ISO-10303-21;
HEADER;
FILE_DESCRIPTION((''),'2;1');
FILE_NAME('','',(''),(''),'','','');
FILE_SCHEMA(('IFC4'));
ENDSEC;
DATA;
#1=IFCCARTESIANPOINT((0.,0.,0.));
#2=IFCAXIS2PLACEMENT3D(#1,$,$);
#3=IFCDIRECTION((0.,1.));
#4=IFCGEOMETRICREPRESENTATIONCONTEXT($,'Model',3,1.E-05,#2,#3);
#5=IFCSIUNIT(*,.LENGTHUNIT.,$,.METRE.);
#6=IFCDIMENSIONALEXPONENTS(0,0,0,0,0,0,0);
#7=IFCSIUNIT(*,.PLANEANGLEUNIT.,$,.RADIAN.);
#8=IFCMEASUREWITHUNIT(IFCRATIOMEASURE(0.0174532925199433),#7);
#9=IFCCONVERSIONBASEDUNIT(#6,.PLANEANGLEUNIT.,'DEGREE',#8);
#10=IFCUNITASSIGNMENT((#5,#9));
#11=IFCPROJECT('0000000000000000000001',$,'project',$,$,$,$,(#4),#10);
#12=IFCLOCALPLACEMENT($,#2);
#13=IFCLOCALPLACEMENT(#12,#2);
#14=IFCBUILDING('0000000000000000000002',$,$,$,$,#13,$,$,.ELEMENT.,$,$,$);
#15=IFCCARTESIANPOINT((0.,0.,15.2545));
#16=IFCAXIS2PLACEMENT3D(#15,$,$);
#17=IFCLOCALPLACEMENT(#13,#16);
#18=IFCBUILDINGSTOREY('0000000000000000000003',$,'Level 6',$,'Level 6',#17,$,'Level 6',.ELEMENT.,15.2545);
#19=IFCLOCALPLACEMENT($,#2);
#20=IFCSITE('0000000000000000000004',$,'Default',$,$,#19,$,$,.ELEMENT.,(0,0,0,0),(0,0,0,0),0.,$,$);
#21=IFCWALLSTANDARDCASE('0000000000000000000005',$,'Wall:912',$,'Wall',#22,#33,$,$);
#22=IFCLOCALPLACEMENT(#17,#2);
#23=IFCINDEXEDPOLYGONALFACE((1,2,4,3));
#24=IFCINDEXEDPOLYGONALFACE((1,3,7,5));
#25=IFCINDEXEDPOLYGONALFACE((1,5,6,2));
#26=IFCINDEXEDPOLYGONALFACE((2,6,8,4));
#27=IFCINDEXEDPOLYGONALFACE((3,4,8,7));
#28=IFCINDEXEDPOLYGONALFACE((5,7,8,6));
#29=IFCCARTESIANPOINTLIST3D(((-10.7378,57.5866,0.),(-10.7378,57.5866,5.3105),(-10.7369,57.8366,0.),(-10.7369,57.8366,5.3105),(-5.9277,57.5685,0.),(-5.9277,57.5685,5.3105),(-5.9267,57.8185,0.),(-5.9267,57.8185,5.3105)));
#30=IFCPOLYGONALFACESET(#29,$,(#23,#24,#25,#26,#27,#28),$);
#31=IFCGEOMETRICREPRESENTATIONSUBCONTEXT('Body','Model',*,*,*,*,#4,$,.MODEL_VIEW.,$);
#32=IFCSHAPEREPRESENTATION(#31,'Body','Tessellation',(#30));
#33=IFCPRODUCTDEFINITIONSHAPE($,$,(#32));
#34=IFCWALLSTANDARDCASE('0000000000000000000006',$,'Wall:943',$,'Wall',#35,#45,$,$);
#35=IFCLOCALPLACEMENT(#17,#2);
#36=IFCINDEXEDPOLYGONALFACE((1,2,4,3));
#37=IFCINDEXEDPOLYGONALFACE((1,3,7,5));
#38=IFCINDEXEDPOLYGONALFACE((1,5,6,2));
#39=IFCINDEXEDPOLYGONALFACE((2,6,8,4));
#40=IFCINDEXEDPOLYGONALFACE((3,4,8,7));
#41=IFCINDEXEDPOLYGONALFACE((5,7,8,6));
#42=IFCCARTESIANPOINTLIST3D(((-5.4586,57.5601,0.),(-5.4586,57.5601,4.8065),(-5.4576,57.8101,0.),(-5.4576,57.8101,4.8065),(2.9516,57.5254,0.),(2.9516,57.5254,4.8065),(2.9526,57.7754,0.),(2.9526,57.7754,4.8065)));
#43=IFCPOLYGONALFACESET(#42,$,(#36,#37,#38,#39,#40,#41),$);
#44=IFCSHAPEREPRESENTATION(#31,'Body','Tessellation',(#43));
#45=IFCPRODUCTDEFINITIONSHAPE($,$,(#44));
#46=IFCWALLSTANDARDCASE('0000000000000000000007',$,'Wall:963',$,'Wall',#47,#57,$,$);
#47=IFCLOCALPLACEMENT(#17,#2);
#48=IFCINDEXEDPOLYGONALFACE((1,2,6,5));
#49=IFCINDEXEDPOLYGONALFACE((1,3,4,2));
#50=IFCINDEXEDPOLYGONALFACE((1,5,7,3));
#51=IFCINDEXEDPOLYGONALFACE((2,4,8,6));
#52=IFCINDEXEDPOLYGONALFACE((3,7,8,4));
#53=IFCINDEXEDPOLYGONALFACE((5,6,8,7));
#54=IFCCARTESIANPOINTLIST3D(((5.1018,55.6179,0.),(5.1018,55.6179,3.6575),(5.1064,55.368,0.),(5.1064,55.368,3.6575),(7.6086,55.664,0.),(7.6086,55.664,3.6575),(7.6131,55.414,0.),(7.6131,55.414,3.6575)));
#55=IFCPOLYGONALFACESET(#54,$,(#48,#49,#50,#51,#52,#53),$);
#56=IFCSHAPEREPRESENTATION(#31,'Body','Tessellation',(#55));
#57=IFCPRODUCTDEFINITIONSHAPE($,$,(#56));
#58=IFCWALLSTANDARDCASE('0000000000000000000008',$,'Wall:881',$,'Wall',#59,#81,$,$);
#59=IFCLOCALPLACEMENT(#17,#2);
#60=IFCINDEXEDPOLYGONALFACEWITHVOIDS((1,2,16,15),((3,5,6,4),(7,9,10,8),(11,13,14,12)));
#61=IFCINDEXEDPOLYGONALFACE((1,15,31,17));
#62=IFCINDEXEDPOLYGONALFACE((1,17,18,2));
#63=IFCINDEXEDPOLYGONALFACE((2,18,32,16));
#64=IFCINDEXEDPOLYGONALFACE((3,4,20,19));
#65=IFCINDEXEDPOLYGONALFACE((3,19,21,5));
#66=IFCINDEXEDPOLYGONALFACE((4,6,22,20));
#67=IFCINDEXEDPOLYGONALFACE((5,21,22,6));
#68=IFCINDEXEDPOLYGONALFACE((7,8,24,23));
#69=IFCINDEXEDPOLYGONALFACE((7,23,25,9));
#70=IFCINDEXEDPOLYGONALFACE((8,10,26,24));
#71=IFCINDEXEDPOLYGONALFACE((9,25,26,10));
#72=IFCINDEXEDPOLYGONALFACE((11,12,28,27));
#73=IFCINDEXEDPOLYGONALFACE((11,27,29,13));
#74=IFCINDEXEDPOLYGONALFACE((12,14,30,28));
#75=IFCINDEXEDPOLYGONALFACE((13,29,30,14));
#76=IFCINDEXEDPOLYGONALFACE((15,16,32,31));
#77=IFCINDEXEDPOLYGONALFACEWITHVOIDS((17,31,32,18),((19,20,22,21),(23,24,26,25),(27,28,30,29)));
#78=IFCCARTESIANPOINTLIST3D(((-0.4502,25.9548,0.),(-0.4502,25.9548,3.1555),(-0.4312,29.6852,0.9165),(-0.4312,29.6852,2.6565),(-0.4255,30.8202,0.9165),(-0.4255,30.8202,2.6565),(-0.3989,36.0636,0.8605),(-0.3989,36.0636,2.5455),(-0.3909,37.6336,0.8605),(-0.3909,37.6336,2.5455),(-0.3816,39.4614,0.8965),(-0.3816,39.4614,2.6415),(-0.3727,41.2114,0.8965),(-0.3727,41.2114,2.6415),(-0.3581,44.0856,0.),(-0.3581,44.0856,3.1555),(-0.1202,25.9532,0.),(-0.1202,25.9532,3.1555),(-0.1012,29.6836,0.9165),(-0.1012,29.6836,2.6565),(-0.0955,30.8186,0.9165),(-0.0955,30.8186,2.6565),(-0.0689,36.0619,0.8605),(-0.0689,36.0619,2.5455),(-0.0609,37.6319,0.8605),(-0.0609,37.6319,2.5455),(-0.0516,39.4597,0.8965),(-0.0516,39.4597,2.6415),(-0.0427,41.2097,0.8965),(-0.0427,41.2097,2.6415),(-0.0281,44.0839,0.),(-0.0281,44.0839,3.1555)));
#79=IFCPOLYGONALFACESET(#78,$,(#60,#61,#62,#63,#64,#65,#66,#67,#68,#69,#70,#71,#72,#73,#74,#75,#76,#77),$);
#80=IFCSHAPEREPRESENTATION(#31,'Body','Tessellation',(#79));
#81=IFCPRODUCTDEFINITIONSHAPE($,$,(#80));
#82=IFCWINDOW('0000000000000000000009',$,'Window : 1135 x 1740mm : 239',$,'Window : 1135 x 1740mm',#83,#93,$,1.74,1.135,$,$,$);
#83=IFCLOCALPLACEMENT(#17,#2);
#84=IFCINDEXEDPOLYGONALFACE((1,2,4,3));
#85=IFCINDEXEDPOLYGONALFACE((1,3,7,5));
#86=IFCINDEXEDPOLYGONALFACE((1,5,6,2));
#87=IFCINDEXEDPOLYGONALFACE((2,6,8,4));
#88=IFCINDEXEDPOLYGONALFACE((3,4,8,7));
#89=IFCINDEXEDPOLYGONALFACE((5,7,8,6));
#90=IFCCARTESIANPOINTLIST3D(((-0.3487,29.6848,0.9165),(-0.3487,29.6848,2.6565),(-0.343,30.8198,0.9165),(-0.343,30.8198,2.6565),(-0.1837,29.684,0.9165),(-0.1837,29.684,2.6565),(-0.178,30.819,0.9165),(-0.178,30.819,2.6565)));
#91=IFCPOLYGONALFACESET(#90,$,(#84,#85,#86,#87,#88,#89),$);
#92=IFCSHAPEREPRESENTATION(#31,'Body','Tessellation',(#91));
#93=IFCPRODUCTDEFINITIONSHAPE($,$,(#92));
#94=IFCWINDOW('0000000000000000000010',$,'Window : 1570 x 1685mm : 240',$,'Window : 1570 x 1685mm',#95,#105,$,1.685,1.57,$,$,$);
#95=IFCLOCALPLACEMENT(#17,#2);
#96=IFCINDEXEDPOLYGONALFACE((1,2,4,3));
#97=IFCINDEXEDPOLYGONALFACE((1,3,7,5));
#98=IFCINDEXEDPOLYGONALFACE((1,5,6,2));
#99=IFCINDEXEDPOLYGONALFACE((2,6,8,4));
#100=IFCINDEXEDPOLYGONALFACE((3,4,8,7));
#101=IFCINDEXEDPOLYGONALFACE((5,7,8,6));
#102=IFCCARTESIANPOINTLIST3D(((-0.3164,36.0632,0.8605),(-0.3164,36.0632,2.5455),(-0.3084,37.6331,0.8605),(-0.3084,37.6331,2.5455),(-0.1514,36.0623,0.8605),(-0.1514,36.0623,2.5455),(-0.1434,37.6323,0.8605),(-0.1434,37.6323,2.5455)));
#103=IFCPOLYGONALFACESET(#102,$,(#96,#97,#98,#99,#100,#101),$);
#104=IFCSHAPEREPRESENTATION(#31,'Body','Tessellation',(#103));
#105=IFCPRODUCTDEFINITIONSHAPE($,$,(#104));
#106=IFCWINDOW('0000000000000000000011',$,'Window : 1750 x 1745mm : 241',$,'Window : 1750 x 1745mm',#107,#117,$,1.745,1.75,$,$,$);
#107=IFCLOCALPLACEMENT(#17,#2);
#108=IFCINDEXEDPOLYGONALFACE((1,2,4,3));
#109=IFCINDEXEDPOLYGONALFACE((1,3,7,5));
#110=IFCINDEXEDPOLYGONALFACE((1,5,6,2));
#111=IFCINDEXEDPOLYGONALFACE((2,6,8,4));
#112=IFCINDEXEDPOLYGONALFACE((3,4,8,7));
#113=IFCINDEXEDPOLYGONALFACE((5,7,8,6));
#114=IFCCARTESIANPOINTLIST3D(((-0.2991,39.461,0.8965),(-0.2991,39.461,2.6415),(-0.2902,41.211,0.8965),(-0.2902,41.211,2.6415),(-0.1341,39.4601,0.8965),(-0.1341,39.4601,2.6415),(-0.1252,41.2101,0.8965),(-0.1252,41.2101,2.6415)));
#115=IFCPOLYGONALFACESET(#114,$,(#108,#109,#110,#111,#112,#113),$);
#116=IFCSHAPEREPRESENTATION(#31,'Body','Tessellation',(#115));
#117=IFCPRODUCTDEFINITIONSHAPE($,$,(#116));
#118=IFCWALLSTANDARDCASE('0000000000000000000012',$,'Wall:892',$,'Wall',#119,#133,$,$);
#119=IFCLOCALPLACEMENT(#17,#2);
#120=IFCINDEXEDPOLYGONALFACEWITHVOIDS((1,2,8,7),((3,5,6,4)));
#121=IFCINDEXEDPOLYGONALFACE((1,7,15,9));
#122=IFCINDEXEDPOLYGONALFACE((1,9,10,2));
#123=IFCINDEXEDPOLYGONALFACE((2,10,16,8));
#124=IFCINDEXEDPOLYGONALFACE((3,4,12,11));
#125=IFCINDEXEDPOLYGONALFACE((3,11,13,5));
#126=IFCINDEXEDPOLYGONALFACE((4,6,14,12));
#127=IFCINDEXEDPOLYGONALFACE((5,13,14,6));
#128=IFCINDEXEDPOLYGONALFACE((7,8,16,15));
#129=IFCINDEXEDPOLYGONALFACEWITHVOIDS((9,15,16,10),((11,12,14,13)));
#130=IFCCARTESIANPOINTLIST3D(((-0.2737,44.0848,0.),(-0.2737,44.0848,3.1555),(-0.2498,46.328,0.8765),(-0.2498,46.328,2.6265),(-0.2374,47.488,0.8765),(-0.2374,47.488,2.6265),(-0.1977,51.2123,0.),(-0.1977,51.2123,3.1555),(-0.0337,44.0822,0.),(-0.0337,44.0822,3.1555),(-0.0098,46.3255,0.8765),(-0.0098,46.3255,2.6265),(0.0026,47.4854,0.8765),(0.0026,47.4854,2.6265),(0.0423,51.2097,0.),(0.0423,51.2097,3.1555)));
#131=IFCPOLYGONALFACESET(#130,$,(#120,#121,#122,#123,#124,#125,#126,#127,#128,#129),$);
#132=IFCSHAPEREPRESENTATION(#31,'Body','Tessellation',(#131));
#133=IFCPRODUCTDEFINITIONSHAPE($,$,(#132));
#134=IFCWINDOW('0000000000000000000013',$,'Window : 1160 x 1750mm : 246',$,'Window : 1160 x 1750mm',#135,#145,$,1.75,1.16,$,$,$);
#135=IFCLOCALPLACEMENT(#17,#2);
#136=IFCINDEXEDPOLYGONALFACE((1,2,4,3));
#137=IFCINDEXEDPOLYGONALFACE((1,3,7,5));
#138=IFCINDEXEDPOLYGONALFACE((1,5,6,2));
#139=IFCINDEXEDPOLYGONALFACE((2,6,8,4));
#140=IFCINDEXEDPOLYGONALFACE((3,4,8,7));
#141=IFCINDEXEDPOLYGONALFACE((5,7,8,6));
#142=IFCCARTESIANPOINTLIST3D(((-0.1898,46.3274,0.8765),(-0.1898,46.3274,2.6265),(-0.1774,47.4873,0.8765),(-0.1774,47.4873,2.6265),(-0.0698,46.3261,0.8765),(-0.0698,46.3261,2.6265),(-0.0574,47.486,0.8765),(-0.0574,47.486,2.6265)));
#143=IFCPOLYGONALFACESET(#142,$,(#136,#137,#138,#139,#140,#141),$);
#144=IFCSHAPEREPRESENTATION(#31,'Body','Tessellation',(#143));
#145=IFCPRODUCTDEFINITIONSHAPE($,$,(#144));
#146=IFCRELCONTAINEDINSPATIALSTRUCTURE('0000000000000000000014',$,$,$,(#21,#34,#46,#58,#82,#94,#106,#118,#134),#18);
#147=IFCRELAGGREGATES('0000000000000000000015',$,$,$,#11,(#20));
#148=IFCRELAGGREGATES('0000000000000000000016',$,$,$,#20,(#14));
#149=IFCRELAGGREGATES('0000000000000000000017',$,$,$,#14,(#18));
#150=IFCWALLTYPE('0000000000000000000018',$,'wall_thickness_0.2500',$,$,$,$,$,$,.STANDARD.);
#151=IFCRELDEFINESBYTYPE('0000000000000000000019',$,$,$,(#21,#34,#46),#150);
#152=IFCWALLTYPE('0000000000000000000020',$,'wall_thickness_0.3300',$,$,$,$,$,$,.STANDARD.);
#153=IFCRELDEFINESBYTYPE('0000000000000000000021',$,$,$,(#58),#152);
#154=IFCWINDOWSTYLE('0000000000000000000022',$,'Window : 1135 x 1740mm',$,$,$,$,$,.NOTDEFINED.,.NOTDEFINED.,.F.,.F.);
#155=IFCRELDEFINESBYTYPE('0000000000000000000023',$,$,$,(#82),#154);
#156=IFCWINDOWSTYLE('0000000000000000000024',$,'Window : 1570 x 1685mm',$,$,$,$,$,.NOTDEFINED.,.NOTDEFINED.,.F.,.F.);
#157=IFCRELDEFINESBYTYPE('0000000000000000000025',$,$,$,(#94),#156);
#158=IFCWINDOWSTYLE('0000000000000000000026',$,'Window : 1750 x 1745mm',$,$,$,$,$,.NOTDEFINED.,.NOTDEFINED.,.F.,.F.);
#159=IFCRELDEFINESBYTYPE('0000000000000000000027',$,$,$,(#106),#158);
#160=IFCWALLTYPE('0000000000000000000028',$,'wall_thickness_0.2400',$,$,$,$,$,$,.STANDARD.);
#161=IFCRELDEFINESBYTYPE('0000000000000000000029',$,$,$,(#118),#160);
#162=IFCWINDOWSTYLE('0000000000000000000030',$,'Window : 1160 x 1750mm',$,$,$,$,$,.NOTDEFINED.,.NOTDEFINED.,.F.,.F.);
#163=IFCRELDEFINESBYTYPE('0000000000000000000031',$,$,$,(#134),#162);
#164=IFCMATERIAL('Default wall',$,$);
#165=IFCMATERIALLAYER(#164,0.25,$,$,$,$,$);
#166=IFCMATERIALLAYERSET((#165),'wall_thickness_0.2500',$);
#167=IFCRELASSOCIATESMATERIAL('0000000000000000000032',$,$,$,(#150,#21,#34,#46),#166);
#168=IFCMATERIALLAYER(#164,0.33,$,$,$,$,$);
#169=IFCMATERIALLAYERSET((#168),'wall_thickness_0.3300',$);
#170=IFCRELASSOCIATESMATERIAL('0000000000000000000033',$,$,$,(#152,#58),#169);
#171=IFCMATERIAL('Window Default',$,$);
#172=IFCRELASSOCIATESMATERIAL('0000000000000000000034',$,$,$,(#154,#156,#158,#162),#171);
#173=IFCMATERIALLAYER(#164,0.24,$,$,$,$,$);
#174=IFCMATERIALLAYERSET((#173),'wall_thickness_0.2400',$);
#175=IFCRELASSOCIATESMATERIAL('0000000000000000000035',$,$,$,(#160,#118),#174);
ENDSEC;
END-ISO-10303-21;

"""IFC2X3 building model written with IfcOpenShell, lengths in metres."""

from ifc_helpers import new_model, entity, si_unit, converted_unit, direction, frame, frame_2d, origin, origin_2d_with_axis, place, context, subcontext, project, spatial, polyline, rectangle, outline, extrude, source, transform, mapped, material, layer, layer_set, layer_usage, type_object, type_shapes, element, fill, save


model = new_model("IFC2X3")

# Units and contexts
model_context = context("Model", 3, precision=1e-05, world=origin(), true_north=direction((0.0, 1.0)))
body_context = subcontext(model_context, "Body", "Model", "MODEL_VIEW")
ifc_project = project(units=[si_unit("LENGTHUNIT", "METRE"), converted_unit("PLANEANGLEUNIT", "DEGREE", entity("IfcRatioMeasure", 0.0174532925199433), si_unit("PLANEANGLEUNIT", "RADIAN"), dimensions=[0, 0, 0, 0, 0, 0, 0])], contexts=[model_context])

# Site, building, storey
site_placement = place(None, origin())
site = spatial("IfcSite", under=ifc_project, at=site_placement, Name="Default", CompositionType="ELEMENT", RefLatitude=(0, 0, 0, 0), RefLongitude=(0, 0, 0, 0), RefElevation=0.0)
placement = place(None, origin())
building_placement = place(placement, origin())
building = spatial("IfcBuilding", under=site, at=building_placement, CompositionType="ELEMENT")
storey_placement = place(building_placement, frame((0.0, 0.0, 15.2545)))
storey = spatial("IfcBuildingStorey", under=building, at=storey_placement, Name="Level 6", ObjectType="Level 6", LongName="Level 6", CompositionType="ELEMENT", Elevation=15.2545)

# Shared definitions
ifc_material_1 = material(Name="Default wall")

# Shared definitions
ifc_layer_1 = layer(ifc_material_1, 0.25)
ifc_layer_set_1 = layer_set([ifc_layer_1], Name="wall_thickness_0.2500")
ifc_layer_usage_1 = layer_usage(ifc_layer_set_1, "AXIS2", "POSITIVE", -0.125)
wall_type_1 = type_object("IfcWallType", Name="wall_thickness_0.2500", PredefinedType="STANDARD", material=ifc_layer_set_1)

# Walls
wall_1_placement = place(storey_placement, frame((-10.7374, 57.7116, 0.0), z_axis=(0.0, 0.0, 1.0), x_axis=(0.999993, -0.003777, 0.0)))
element("IfcWallStandardCase", 1, at=wall_1_placement, inside=storey, type_object=wall_type_1, material=ifc_layer_usage_1, Name="Wall:912", ObjectType="Wall", context=body_context, shape_type="SweptSolid", body=[
    extrude(outline(polyline([(4.8102, -0.125), (4.8102, 0.125), (0.0, 0.125), (0.0, -0.125), (4.8102, -0.125)])), origin(), (0.0, 0.0, 1.0), 5.3105),
])
wall_2_placement = place(storey_placement, frame((-5.4581, 57.6851, 0.0), z_axis=(0.0, 0.0, 1.0), x_axis=(0.999992, -0.004119, 0.0)))
element("IfcWallStandardCase", 2, at=wall_2_placement, inside=storey, type_object=wall_type_1, material=ifc_layer_usage_1, Name="Wall:943", ObjectType="Wall", context=body_context, shape_type="SweptSolid", body=[
    extrude(outline(polyline([(8.4103, -0.125), (8.4103, 0.125), (0.0, 0.125), (0.0, -0.125), (8.4103, -0.125)])), origin(), (0.0, 0.0, 1.0), 4.8065),
])
wall_3_placement = place(storey_placement, frame((5.1041, 55.4929, 0.0), z_axis=(0.0, 0.0, 1.0), x_axis=(0.999831, 0.018363, 0.0)))
element("IfcWallStandardCase", 3, at=wall_3_placement, inside=storey, type_object=wall_type_1, material=ifc_layer_usage_1, Name="Wall:963", ObjectType="Wall", context=body_context, shape_type="SweptSolid", body=[
    extrude(outline(polyline([(2.5072, -0.125), (2.5072, 0.125), (0.0, 0.125), (0.0, -0.125), (2.5072, -0.125)])), origin(), (0.0, 0.0, 1.0), 3.6575),
])

# Wall, openings, windows
ifc_layer_2 = layer(ifc_material_1, 0.33)
ifc_layer_set_2 = layer_set([ifc_layer_2], Name="wall_thickness_0.3300")
ifc_layer_usage_2 = layer_usage(ifc_layer_set_2, "AXIS2", "POSITIVE", -0.165)
wall_type_2 = type_object("IfcWallType", Name="wall_thickness_0.3300", PredefinedType="STANDARD", material=ifc_layer_set_2)
wall_4_placement = place(storey_placement, frame((-0.1931, 44.0847, 0.0), z_axis=(0.0, 0.0, 1.0), x_axis=(-0.005077, -0.999987, 0.0)))
wall_4 = element("IfcWallStandardCase", 4, at=wall_4_placement, inside=storey, type_object=wall_type_2, material=ifc_layer_usage_2, Name="Wall:881", ObjectType="Wall", context=body_context, shape_type="SweptSolid", body=[
    extrude(outline(polyline([(18.131, -0.165), (18.131, 0.165), (0.0, 0.165), (0.0, -0.165), (18.131, -0.165)])), origin(), (0.0, 0.0, 1.0), 3.1555),
])
opening_1_placement = place(wall_4_placement, frame((13.2655, -0.165, 0.9165)))
opening_1 = element("IfcOpeningElement", 5, at=opening_1_placement, cuts=wall_4, ObjectType="Opening", context=body_context, shape_type="SweptSolid", body=[
    extrude(rectangle(XDim=1.135, YDim=1.74, at=frame_2d((0.87, 0.5675), x_axis=(0.0, 1.0))), frame((0.0, 0.0, 0.0), z_axis=(0.0, 1.0, 0.0), x_axis=(0.0, 0.0, 1.0)), (0.0, 0.0, 1.0), 0.33),
])
opening_2_placement = place(wall_4_placement, frame((6.4521, -0.165, 0.8605)))
opening_2 = element("IfcOpeningElement", 6, at=opening_2_placement, cuts=wall_4, ObjectType="Opening", context=body_context, shape_type="SweptSolid", body=[
    extrude(rectangle(XDim=1.57, YDim=1.685, at=frame_2d((0.8425, 0.785), x_axis=(0.0, 1.0))), frame((0.0, 0.0, 0.0), z_axis=(0.0, 1.0, 0.0), x_axis=(0.0, 0.0, 1.0)), (0.0, 0.0, 1.0), 0.33),
])
opening_3_placement = place(wall_4_placement, frame((2.8742, -0.165, 0.8965)))
opening_3 = element("IfcOpeningElement", 7, at=opening_3_placement, cuts=wall_4, ObjectType="Opening", context=body_context, shape_type="SweptSolid", body=[
    extrude(rectangle(XDim=1.75, YDim=1.745, at=frame_2d((0.8725, 0.875), x_axis=(0.0, 1.0))), frame((0.0, 0.0, 0.0), z_axis=(0.0, 1.0, 0.0), x_axis=(0.0, 0.0, 1.0)), (0.0, 0.0, 1.0), 0.33),
])
ifc_material_2 = material(Name="Window Default")
window_style_1 = type_object("IfcWindowStyle", Name="Window : 1135 x 1740mm", ConstructionType="NOTDEFINED", OperationType="NOTDEFINED", ParameterTakesPrecedence=False, Sizeable=False, material=ifc_material_2)
shared_shape_1 = source(origin(), body_context, "Body", "SweptSolid", [
    extrude(rectangle(XDim=0.165, YDim=1.135, at=origin_2d_with_axis()), frame((0.5675, 0.165, 0.0), z_axis=(0.0, 0.0, 1.0), x_axis=(0.0, 1.0, 0.0)), (0.0, 0.0, 1.0), 1.74),
])
type_shapes(window_style_1, [shared_shape_1])
window_1_placement = place(opening_1_placement, origin())
window_1 = element("IfcWindow", 8, at=window_1_placement, inside=storey, type_object=window_style_1, Name="Window : 1135 x 1740mm : 239", ObjectType="Window : 1135 x 1740mm", OverallHeight=1.74, OverallWidth=1.135, context=body_context, shape_type="MappedRepresentation", body=[
    mapped(shared_shape_1, transform((0.0, 0.0, 0.0), scale=1.0)),
])
fill(opening_1, window_1)
window_style_2 = type_object("IfcWindowStyle", Name="Window : 1570 x 1685mm", ConstructionType="NOTDEFINED", OperationType="NOTDEFINED", ParameterTakesPrecedence=False, Sizeable=False, material=ifc_material_2)
shared_shape_2 = source(origin(), body_context, "Body", "SweptSolid", [
    extrude(rectangle(XDim=0.165, YDim=1.57, at=origin_2d_with_axis()), frame((0.785, 0.165, 0.0), z_axis=(0.0, 0.0, 1.0), x_axis=(0.0, 1.0, 0.0)), (0.0, 0.0, 1.0), 1.685),
])
type_shapes(window_style_2, [shared_shape_2])
window_2_placement = place(opening_2_placement, origin())
window_2 = element("IfcWindow", 9, at=window_2_placement, inside=storey, type_object=window_style_2, Name="Window : 1570 x 1685mm : 240", ObjectType="Window : 1570 x 1685mm", OverallHeight=1.685, OverallWidth=1.57, context=body_context, shape_type="MappedRepresentation", body=[
    mapped(shared_shape_2, transform((0.0, 0.0, 0.0), scale=1.0)),
])
fill(opening_2, window_2)
window_style_3 = type_object("IfcWindowStyle", Name="Window : 1750 x 1745mm", ConstructionType="NOTDEFINED", OperationType="NOTDEFINED", ParameterTakesPrecedence=False, Sizeable=False, material=ifc_material_2)
shared_shape_3 = source(origin(), body_context, "Body", "SweptSolid", [
    extrude(rectangle(XDim=0.165, YDim=1.75, at=origin_2d_with_axis()), frame((0.875, 0.165, 0.0), z_axis=(0.0, 0.0, 1.0), x_axis=(0.0, 1.0, 0.0)), (0.0, 0.0, 1.0), 1.745),
])
type_shapes(window_style_3, [shared_shape_3])
window_3_placement = place(opening_3_placement, origin())
window_3 = element("IfcWindow", 10, at=window_3_placement, inside=storey, type_object=window_style_3, Name="Window : 1750 x 1745mm : 241", ObjectType="Window : 1750 x 1745mm", OverallHeight=1.745, OverallWidth=1.75, context=body_context, shape_type="MappedRepresentation", body=[
    mapped(shared_shape_3, transform((0.0, 0.0, 0.0), scale=1.0)),
])
fill(opening_3, window_3)

# Wall, opening, window
ifc_layer_3 = layer(ifc_material_1, 0.24)
ifc_layer_set_3 = layer_set([ifc_layer_3], Name="wall_thickness_0.2400")
ifc_layer_usage_3 = layer_usage(ifc_layer_set_3, "AXIS2", "POSITIVE", -0.12)
wall_type_3 = type_object("IfcWallType", Name="wall_thickness_0.2400", PredefinedType="STANDARD", material=ifc_layer_set_3)
wall_5_placement = place(storey_placement, frame((-0.0777, 51.211, 0.0), z_axis=(0.0, 0.0, 1.0), x_axis=(-0.010659, -0.999943, 0.0)))
wall_5 = element("IfcWallStandardCase", 11, at=wall_5_placement, inside=storey, type_object=wall_type_3, material=ifc_layer_usage_3, Name="Wall:892", ObjectType="Wall", context=body_context, shape_type="SweptSolid", body=[
    extrude(outline(polyline([(7.1279, -0.12), (7.1279, 0.12), (0.0, 0.12), (0.0, -0.12), (7.1279, -0.12)])), origin(), (0.0, 0.0, 1.0), 3.1555),
])
opening_4_placement = place(wall_5_placement, frame((3.7245, -0.12, 0.8765)))
opening_4 = element("IfcOpeningElement", 12, at=opening_4_placement, cuts=wall_5, ObjectType="Opening", context=body_context, shape_type="SweptSolid", body=[
    extrude(rectangle(XDim=1.16, YDim=1.75, at=frame_2d((0.875, 0.58), x_axis=(0.0, 1.0))), frame((0.0, 0.0, 0.0), z_axis=(0.0, 1.0, 0.0), x_axis=(0.0, 0.0, 1.0)), (0.0, 0.0, 1.0), 0.24),
])
window_style_4 = type_object("IfcWindowStyle", Name="Window : 1160 x 1750mm", ConstructionType="NOTDEFINED", OperationType="NOTDEFINED", ParameterTakesPrecedence=False, Sizeable=False, material=ifc_material_2)
shared_shape_4 = source(origin(), body_context, "Body", "SweptSolid", [
    extrude(rectangle(XDim=0.12, YDim=1.16, at=origin_2d_with_axis()), frame((0.58, 0.12, 0.0), z_axis=(0.0, 0.0, 1.0), x_axis=(0.0, 1.0, 0.0)), (0.0, 0.0, 1.0), 1.75),
])
type_shapes(window_style_4, [shared_shape_4])
window_4_placement = place(opening_4_placement, origin())
window_4 = element("IfcWindow", 13, at=window_4_placement, inside=storey, type_object=window_style_4, Name="Window : 1160 x 1750mm : 246", ObjectType="Window : 1160 x 1750mm", OverallHeight=1.75, OverallWidth=1.16, context=body_context, shape_type="MappedRepresentation", body=[
    mapped(shared_shape_4, transform((0.0, 0.0, 0.0), scale=1.0)),
])
fill(opening_4, window_4)

save(model, "model.ifc")
